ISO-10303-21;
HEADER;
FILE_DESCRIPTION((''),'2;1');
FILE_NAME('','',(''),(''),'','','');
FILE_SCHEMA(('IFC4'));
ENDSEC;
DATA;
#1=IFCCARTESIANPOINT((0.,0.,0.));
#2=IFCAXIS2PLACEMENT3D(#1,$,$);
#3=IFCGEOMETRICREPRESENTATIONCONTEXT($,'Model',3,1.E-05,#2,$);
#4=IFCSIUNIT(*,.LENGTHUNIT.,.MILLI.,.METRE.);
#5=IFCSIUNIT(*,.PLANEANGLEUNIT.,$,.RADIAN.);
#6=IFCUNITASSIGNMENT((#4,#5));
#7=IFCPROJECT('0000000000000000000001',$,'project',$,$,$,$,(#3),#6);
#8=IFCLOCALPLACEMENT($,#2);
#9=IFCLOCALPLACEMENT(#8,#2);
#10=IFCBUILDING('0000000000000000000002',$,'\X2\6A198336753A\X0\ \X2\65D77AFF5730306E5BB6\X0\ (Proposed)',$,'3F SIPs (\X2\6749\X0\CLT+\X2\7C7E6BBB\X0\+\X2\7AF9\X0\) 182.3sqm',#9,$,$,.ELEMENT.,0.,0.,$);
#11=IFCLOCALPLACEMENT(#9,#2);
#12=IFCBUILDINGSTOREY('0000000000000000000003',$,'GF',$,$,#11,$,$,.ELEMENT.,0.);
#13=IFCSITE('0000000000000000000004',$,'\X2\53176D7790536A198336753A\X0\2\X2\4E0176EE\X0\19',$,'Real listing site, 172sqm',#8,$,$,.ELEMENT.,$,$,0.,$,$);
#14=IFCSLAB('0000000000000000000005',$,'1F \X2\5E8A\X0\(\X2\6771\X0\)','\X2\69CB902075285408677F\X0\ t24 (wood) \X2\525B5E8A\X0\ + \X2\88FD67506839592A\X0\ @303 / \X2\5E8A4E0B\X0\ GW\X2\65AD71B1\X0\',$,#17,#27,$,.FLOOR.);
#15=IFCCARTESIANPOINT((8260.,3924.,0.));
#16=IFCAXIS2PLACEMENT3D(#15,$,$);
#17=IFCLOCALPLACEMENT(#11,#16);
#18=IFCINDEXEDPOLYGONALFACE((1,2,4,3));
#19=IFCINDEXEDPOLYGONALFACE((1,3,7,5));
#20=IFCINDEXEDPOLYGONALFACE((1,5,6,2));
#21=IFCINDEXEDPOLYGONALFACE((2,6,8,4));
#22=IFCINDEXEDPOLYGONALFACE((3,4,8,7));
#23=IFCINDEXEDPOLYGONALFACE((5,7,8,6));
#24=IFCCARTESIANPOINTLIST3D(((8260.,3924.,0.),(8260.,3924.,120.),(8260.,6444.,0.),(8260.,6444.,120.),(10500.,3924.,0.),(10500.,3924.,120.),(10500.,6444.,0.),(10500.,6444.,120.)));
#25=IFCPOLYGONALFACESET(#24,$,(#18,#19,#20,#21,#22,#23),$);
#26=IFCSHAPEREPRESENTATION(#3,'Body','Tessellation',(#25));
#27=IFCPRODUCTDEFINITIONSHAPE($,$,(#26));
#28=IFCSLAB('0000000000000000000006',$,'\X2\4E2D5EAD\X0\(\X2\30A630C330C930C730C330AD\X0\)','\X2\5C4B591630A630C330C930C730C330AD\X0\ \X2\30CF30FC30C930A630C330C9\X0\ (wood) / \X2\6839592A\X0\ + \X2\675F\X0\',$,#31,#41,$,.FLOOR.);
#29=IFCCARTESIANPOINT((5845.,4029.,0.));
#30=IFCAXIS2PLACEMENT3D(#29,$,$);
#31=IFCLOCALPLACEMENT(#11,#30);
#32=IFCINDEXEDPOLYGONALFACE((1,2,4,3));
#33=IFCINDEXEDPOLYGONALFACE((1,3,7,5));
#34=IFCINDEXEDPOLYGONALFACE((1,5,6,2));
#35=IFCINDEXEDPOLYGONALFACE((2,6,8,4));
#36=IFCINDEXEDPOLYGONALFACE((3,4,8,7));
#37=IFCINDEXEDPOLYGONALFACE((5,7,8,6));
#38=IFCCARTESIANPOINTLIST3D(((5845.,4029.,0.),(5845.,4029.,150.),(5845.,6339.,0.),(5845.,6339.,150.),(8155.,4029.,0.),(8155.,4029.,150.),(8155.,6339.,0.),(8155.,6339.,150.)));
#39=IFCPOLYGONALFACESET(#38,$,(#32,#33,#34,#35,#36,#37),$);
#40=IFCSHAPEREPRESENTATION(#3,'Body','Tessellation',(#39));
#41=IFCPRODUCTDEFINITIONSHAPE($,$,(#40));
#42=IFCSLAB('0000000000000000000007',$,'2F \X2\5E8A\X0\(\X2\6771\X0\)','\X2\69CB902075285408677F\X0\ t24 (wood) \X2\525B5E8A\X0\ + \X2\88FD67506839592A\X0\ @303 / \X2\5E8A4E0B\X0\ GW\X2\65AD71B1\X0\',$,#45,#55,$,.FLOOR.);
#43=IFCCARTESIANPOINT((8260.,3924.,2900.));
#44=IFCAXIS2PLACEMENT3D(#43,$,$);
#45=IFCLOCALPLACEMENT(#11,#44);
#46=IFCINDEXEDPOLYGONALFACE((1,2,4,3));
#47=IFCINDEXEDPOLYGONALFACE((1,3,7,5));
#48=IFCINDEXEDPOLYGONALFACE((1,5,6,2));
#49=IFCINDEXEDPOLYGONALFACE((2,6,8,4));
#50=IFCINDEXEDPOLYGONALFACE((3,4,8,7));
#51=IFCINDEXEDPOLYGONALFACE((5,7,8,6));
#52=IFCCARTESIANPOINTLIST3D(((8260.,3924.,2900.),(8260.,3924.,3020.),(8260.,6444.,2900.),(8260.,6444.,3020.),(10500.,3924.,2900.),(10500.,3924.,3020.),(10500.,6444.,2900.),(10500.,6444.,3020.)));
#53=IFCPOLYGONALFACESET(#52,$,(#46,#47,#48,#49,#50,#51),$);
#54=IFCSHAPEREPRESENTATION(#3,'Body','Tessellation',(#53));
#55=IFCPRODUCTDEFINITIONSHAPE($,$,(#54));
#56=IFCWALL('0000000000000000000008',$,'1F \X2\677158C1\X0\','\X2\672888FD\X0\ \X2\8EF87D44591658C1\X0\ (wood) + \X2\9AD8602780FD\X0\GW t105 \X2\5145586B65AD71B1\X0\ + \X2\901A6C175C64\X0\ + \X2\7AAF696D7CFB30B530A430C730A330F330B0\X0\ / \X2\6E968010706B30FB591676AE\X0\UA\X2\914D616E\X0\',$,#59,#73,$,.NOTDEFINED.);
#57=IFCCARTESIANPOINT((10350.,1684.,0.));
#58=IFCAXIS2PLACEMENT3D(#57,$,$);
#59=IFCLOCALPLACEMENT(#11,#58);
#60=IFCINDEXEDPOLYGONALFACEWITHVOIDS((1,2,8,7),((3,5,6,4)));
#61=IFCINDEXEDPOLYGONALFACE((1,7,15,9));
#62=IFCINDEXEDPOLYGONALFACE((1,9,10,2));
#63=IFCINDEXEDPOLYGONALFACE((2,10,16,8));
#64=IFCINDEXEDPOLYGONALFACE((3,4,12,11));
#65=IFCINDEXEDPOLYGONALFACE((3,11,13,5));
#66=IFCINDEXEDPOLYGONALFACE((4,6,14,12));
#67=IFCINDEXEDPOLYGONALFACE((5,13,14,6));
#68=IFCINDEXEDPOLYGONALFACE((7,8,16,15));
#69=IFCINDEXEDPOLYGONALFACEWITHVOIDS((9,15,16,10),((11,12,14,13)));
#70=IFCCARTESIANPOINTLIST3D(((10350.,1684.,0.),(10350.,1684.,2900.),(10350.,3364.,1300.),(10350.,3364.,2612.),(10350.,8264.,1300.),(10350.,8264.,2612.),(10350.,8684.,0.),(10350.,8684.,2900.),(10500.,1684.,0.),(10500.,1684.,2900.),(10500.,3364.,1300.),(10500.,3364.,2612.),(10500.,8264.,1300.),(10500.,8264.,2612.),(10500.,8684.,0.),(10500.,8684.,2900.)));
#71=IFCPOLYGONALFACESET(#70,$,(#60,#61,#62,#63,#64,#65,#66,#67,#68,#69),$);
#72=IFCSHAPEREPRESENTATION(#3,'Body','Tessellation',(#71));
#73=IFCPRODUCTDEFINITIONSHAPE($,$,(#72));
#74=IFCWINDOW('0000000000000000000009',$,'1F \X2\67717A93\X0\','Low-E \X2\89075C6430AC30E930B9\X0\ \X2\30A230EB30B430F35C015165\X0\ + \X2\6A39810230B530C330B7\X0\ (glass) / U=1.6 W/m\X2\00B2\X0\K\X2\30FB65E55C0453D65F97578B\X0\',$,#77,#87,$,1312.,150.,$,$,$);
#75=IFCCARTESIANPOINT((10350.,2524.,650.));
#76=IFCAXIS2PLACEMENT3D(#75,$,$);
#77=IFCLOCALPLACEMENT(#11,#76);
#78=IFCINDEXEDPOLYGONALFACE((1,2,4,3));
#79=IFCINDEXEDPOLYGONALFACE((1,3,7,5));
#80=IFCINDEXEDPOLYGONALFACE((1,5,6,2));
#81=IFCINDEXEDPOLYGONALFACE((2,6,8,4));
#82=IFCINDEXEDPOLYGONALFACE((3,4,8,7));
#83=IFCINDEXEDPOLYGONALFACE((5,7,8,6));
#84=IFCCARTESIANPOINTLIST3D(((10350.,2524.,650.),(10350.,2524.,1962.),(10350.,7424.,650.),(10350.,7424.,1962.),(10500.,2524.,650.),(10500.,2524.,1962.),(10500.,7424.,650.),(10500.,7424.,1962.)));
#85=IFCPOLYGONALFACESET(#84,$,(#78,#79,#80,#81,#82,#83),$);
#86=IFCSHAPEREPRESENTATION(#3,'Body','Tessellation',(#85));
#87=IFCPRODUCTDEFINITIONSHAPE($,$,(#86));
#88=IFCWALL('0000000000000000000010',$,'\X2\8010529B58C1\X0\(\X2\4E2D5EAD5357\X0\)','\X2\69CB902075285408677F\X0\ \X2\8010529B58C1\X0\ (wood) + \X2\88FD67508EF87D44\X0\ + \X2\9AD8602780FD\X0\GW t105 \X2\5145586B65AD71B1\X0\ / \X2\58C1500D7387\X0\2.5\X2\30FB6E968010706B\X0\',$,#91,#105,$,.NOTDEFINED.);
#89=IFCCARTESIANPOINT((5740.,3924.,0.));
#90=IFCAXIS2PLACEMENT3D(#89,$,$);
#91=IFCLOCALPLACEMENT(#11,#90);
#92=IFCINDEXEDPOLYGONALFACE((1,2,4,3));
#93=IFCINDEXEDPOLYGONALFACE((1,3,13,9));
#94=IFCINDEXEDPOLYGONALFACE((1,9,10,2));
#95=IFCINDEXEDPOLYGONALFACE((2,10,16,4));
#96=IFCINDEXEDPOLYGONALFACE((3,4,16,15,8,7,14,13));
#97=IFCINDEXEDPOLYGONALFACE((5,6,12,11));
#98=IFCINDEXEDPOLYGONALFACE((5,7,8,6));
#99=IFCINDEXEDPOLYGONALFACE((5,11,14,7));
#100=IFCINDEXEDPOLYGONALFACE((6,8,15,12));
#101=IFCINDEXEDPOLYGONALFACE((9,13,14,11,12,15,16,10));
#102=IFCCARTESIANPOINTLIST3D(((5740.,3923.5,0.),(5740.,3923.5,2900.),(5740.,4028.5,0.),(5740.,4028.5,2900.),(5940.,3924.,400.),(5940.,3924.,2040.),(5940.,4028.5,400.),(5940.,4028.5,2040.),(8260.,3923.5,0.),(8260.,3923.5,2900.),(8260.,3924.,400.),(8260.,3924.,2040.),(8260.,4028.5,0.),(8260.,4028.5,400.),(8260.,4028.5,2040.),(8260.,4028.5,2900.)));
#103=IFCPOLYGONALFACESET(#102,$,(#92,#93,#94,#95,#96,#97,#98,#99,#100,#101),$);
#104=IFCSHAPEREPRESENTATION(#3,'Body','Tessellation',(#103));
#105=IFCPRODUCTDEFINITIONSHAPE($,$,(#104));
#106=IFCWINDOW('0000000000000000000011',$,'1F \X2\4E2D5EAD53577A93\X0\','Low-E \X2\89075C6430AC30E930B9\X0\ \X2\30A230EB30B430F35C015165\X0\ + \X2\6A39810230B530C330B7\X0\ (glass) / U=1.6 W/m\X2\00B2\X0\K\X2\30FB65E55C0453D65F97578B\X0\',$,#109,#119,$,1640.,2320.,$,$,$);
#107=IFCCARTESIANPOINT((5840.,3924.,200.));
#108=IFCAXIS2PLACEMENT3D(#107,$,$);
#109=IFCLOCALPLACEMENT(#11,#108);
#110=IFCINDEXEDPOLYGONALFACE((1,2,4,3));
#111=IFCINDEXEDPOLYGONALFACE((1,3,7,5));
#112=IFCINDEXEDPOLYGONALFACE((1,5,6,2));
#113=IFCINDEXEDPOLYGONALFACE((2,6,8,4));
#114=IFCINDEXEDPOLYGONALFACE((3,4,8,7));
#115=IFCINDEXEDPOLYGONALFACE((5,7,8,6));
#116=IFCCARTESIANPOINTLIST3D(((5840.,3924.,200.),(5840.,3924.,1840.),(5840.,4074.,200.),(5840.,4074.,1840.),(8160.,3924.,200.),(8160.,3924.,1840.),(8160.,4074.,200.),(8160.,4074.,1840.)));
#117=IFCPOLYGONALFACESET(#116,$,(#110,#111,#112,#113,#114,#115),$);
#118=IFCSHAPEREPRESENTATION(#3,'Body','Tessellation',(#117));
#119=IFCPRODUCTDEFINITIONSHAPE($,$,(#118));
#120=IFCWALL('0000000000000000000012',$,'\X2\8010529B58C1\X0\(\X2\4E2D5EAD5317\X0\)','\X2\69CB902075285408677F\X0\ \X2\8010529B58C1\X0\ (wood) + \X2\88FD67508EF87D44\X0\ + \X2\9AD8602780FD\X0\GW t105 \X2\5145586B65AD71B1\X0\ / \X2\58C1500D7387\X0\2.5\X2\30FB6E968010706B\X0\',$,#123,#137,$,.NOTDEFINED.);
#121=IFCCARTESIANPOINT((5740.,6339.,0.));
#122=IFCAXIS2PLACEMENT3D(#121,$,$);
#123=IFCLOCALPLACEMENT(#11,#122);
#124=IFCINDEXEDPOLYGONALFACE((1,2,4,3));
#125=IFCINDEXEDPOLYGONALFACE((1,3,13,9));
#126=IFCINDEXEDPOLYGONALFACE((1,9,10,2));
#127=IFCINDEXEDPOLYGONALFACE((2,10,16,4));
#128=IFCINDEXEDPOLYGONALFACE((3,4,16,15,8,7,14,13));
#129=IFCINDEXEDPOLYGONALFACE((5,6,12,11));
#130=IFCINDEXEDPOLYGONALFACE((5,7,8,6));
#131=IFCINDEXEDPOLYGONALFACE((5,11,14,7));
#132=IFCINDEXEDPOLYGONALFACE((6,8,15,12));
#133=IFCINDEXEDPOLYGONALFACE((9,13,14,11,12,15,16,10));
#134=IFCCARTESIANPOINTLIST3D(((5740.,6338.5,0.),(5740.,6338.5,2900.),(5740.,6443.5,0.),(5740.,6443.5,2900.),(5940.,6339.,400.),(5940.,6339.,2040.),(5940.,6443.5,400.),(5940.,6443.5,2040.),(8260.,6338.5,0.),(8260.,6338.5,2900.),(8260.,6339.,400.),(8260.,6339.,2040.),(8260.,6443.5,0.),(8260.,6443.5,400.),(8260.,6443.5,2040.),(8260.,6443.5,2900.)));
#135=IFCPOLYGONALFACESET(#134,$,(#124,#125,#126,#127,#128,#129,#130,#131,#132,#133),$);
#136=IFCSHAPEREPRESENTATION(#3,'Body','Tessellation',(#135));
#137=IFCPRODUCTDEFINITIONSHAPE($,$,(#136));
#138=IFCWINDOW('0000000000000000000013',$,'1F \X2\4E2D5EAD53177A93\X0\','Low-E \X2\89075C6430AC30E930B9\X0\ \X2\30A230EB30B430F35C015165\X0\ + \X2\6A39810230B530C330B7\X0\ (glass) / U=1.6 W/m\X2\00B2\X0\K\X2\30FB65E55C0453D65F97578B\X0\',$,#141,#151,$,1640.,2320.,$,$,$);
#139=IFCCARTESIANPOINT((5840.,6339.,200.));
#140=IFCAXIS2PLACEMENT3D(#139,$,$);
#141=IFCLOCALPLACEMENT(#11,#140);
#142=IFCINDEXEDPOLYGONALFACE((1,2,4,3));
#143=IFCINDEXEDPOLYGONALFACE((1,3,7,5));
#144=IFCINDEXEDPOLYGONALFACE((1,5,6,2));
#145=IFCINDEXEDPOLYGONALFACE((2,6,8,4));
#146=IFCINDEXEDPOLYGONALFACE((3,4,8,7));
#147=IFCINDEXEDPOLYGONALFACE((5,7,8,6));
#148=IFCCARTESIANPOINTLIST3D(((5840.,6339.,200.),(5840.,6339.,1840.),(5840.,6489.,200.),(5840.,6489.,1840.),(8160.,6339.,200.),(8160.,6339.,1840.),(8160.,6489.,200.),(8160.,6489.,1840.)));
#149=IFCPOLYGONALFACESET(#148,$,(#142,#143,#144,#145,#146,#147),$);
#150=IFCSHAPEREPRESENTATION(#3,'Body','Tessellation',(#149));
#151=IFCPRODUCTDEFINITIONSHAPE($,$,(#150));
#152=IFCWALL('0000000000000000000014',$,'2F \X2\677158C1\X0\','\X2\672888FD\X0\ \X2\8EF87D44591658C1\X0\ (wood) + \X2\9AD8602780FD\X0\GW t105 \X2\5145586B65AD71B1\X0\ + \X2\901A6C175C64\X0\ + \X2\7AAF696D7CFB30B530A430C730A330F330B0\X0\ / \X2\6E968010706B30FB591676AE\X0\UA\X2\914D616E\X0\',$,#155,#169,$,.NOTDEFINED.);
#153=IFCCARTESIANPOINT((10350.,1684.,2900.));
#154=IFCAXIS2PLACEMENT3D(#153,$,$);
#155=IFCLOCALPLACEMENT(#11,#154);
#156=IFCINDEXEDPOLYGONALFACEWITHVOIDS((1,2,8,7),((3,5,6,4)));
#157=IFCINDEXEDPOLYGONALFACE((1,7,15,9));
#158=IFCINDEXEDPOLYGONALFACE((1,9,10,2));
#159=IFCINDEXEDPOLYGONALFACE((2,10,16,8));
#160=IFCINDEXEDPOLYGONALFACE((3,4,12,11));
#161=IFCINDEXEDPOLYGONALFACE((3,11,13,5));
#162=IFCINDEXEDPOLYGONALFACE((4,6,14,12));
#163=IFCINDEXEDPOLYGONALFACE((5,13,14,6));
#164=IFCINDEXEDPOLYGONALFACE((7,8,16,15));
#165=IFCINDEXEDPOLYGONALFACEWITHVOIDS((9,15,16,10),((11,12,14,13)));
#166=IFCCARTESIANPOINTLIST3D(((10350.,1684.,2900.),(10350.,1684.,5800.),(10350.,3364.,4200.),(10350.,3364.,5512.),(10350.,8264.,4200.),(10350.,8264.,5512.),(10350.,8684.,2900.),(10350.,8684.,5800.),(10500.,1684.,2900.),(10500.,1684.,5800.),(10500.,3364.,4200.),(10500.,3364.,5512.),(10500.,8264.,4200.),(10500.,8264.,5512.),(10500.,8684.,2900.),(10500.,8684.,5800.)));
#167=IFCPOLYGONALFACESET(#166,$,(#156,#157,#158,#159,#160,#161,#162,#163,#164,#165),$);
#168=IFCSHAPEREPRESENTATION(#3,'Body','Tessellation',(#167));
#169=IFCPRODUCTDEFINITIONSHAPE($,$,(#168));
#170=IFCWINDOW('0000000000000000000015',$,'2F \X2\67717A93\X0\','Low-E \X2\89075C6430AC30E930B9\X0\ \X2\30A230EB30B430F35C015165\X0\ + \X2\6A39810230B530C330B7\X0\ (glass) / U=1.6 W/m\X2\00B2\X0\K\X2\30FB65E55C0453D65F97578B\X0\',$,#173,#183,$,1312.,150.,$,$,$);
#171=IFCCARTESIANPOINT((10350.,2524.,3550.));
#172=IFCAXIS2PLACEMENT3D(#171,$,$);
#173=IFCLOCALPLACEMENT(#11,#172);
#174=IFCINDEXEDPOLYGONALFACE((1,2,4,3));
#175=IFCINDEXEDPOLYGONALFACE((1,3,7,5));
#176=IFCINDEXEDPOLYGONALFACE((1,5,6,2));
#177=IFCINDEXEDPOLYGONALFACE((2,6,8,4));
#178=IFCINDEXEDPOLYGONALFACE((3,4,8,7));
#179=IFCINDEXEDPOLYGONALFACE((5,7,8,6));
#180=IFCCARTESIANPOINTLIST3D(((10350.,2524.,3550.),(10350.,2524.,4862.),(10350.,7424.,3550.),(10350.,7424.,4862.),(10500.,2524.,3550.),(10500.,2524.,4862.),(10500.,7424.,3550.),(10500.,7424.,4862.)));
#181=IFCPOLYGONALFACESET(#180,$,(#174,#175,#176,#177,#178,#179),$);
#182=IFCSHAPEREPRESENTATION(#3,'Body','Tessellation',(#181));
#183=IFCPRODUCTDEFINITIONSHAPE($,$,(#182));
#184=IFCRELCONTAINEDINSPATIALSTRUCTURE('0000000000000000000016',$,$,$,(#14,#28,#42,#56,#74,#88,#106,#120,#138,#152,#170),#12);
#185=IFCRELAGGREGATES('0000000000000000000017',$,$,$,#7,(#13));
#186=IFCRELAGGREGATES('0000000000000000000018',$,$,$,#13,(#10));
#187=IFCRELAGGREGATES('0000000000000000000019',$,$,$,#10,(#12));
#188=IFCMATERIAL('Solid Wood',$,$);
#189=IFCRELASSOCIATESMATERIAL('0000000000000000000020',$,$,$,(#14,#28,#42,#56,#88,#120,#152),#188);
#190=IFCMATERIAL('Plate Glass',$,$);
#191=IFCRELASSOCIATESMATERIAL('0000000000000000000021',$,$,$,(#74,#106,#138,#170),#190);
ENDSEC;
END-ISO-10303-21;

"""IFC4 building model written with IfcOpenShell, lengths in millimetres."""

from ifc_helpers import new_model, si_unit, frame, frame_2d, origin, place, context, project, spatial, rectangle, extrude, material, element, fill, save


model = new_model("IFC4")

# Units and contexts
model_context = context("Model", 3, precision=1e-05, world=origin())
ifc_project = project(units=[si_unit("LENGTHUNIT", "METRE", prefix="MILLI"), si_unit("PLANEANGLEUNIT", "RADIAN")], contexts=[model_context])

# Site, building, storey
site_placement = place(None, origin())
site = spatial("IfcSite", under=ifc_project, at=site_placement, Name="北海道標茶町2丁目19", ObjectType="Real listing site, 172sqm", CompositionType="ELEMENT", RefElevation=0.0)
building_placement = place(site_placement, origin())
building = spatial("IfcBuilding", under=site, at=building_placement, Name="標茶町 旗竿地の家 (Proposed)", ObjectType="3F SIPs (杉CLT+籾殻+竹) 182.3sqm", CompositionType="ELEMENT", ElevationOfRefHeight=0.0, ElevationOfTerrain=0.0)
storey_placement = place(building_placement, origin())
storey = spatial("IfcBuildingStorey", under=building, at=storey_placement, Name="GF", CompositionType="ELEMENT", Elevation=0.0)

# Slabs
ifc_material_1 = material(Name="Solid Wood")
slab_1_placement = place(storey_placement, frame((8260.0, 3924.0, 0.0)))
element("IfcSlab", 1, at=slab_1_placement, inside=storey, material=ifc_material_1, Name="1F 床(東)", Description="構造用合板 t24 (wood) 剛床 + 製材根太 @303 / 床下 GW断熱", PredefinedType="FLOOR", context=model_context, shape_type="SweptSolid", body=[
    extrude(rectangle(XDim=2240.0, YDim=2520.0, at=frame_2d((1120.0, 1260.0))), frame((8260.0, 3924.0, 0.0)), (0.0, 0.0, 1.0), 120.0),
])
slab_2_placement = place(storey_placement, frame((5845.0, 4029.0, 0.0)))
element("IfcSlab", 2, at=slab_2_placement, inside=storey, material=ifc_material_1, Name="中庭(ウッドデッキ)", Description="屋外ウッドデッキ ハードウッド (wood) / 根太 + 束", PredefinedType="FLOOR", context=model_context, shape_type="SweptSolid", body=[
    extrude(rectangle(XDim=2310.0, YDim=2310.0, at=frame_2d((1155.0, 1155.0))), frame((5845.0, 4029.0, 0.0)), (0.0, 0.0, 1.0), 150.0),
])
slab_3_placement = place(storey_placement, frame((8260.0, 3924.0, 2900.0)))
element("IfcSlab", 3, at=slab_3_placement, inside=storey, material=ifc_material_1, Name="2F 床(東)", Description="構造用合板 t24 (wood) 剛床 + 製材根太 @303 / 床下 GW断熱", PredefinedType="FLOOR", context=model_context, shape_type="SweptSolid", body=[
    extrude(rectangle(XDim=2240.0, YDim=2520.0, at=frame_2d((1120.0, 1260.0))), frame((8260.0, 3924.0, 2900.0)), (0.0, 0.0, 1.0), 120.0),
])

# Walls, openings, windows
wall_1_placement = place(storey_placement, frame((10350.0, 1684.0, 0.0)))
wall_1 = element("IfcWall", 4, at=wall_1_placement, inside=storey, material=ifc_material_1, Name="1F 東壁", Description="木製 軸組外壁 (wood) + 高性能GW t105 充填断熱 + 通気層 + 窯業系サイディング / 準耐火・外皮UA配慮", PredefinedType="NOTDEFINED", context=model_context, shape_type="SweptSolid", body=[
    extrude(rectangle(XDim=150.0, YDim=7000.0, at=frame_2d((75.0, 3500.0))), frame((10350.0, 1684.0, 0.0)), (0.0, 0.0, 1.0), 2900.0),
])
opening_1_placement = place(storey_placement, frame((10350.0, 2524.0, 650.0)))
opening_1 = element("IfcOpeningElement", 5, at=opening_1_placement, cuts=wall_1, PredefinedType="NOTDEFINED", context=model_context, shape_type="SweptSolid", body=[
    extrude(rectangle(XDim=150.0, YDim=4900.0, at=frame_2d((75.0, 2450.0))), frame((10350.0, 2524.0, 650.0)), (0.0, 0.0, 1.0), 1312.0),
])
ifc_material_2 = material(Name="Plate Glass")
window_1_placement = place(storey_placement, frame((10350.0, 2524.0, 650.0)))
window_1 = element("IfcWindow", 6, at=window_1_placement, inside=storey, material=ifc_material_2, Name="1F 東窓", Description="Low-E 複層ガラス アルゴン封入 + 樹脂サッシ (glass) / U=1.6 W/m²K・日射取得型", OverallHeight=1312.0, OverallWidth=150.0, context=model_context, shape_type="SweptSolid", body=[
    extrude(rectangle(XDim=150.0, YDim=4900.0, at=frame_2d((75.0, 2450.0))), frame((10350.0, 2524.0, 650.0)), (0.0, 0.0, 1.0), 1312.0),
])
fill(opening_1, window_1)
wall_2_placement = place(storey_placement, frame((5740.0, 3924.0, 0.0)))
wall_2 = element("IfcWall", 7, at=wall_2_placement, inside=storey, material=ifc_material_1, Name="耐力壁(中庭南)", Description="構造用合板 耐力壁 (wood) + 製材軸組 + 高性能GW t105 充填断熱 / 壁倍率2.5・準耐火", PredefinedType="NOTDEFINED", context=model_context, shape_type="SweptSolid", body=[
    extrude(rectangle(XDim=2520.0, YDim=105.0, at=frame_2d((1260.0, 52.0))), frame((5740.0, 3924.0, 0.0)), (0.0, 0.0, 1.0), 2900.0),
])
opening_2_placement = place(storey_placement, frame((5840.0, 3924.0, 200.0)))
opening_2 = element("IfcOpeningElement", 8, at=opening_2_placement, cuts=wall_2, PredefinedType="NOTDEFINED", context=model_context, shape_type="SweptSolid", body=[
    extrude(rectangle(XDim=2320.0, YDim=150.0, at=frame_2d((1160.0, 75.0))), frame((5840.0, 3924.0, 200.0)), (0.0, 0.0, 1.0), 1640.0),
])
window_2_placement = place(storey_placement, frame((5840.0, 3924.0, 200.0)))
window_2 = element("IfcWindow", 9, at=window_2_placement, inside=storey, material=ifc_material_2, Name="1F 中庭南窓", Description="Low-E 複層ガラス アルゴン封入 + 樹脂サッシ (glass) / U=1.6 W/m²K・日射取得型", OverallHeight=1640.0, OverallWidth=2320.0, context=model_context, shape_type="SweptSolid", body=[
    extrude(rectangle(XDim=2320.0, YDim=150.0, at=frame_2d((1160.0, 75.0))), frame((5840.0, 3924.0, 200.0)), (0.0, 0.0, 1.0), 1640.0),
])
fill(opening_2, window_2)
wall_3_placement = place(storey_placement, frame((5740.0, 6339.0, 0.0)))
wall_3 = element("IfcWall", 10, at=wall_3_placement, inside=storey, material=ifc_material_1, Name="耐力壁(中庭北)", Description="構造用合板 耐力壁 (wood) + 製材軸組 + 高性能GW t105 充填断熱 / 壁倍率2.5・準耐火", PredefinedType="NOTDEFINED", context=model_context, shape_type="SweptSolid", body=[
    extrude(rectangle(XDim=2520.0, YDim=105.0, at=frame_2d((1260.0, 52.0))), frame((5740.0, 6339.0, 0.0)), (0.0, 0.0, 1.0), 2900.0),
])
opening_3_placement = place(storey_placement, frame((5840.0, 6339.0, 200.0)))
opening_3 = element("IfcOpeningElement", 11, at=opening_3_placement, cuts=wall_3, PredefinedType="NOTDEFINED", context=model_context, shape_type="SweptSolid", body=[
    extrude(rectangle(XDim=2320.0, YDim=150.0, at=frame_2d((1160.0, 75.0))), frame((5840.0, 6339.0, 200.0)), (0.0, 0.0, 1.0), 1640.0),
])
window_3_placement = place(storey_placement, frame((5840.0, 6339.0, 200.0)))
window_3 = element("IfcWindow", 12, at=window_3_placement, inside=storey, material=ifc_material_2, Name="1F 中庭北窓", Description="Low-E 複層ガラス アルゴン封入 + 樹脂サッシ (glass) / U=1.6 W/m²K・日射取得型", OverallHeight=1640.0, OverallWidth=2320.0, context=model_context, shape_type="SweptSolid", body=[
    extrude(rectangle(XDim=2320.0, YDim=150.0, at=frame_2d((1160.0, 75.0))), frame((5840.0, 6339.0, 200.0)), (0.0, 0.0, 1.0), 1640.0),
])
fill(opening_3, window_3)

# Wall, opening, window
wall_4_placement = place(storey_placement, frame((10350.0, 1684.0, 2900.0)))
wall_4 = element("IfcWall", 13, at=wall_4_placement, inside=storey, material=ifc_material_1, Name="2F 東壁", Description="木製 軸組外壁 (wood) + 高性能GW t105 充填断熱 + 通気層 + 窯業系サイディング / 準耐火・外皮UA配慮", PredefinedType="NOTDEFINED", context=model_context, shape_type="SweptSolid", body=[
    extrude(rectangle(XDim=150.0, YDim=7000.0, at=frame_2d((75.0, 3500.0))), frame((10350.0, 1684.0, 2900.0)), (0.0, 0.0, 1.0), 2900.0),
])
opening_4_placement = place(storey_placement, frame((10350.0, 2524.0, 3550.0)))
opening_4 = element("IfcOpeningElement", 14, at=opening_4_placement, cuts=wall_4, PredefinedType="NOTDEFINED", context=model_context, shape_type="SweptSolid", body=[
    extrude(rectangle(XDim=150.0, YDim=4900.0, at=frame_2d((75.0, 2450.0))), frame((10350.0, 2524.0, 3550.0)), (0.0, 0.0, 1.0), 1312.0),
])
window_4_placement = place(storey_placement, frame((10350.0, 2524.0, 3550.0)))
window_4 = element("IfcWindow", 15, at=window_4_placement, inside=storey, material=ifc_material_2, Name="2F 東窓", Description="Low-E 複層ガラス アルゴン封入 + 樹脂サッシ (glass) / U=1.6 W/m²K・日射取得型", OverallHeight=1312.0, OverallWidth=150.0, context=model_context, shape_type="SweptSolid", body=[
    extrude(rectangle(XDim=150.0, YDim=4900.0, at=frame_2d((75.0, 2450.0))), frame((10350.0, 2524.0, 3550.0)), (0.0, 0.0, 1.0), 1312.0),
])
fill(opening_4, window_4)

save(model, "model.ifc")
